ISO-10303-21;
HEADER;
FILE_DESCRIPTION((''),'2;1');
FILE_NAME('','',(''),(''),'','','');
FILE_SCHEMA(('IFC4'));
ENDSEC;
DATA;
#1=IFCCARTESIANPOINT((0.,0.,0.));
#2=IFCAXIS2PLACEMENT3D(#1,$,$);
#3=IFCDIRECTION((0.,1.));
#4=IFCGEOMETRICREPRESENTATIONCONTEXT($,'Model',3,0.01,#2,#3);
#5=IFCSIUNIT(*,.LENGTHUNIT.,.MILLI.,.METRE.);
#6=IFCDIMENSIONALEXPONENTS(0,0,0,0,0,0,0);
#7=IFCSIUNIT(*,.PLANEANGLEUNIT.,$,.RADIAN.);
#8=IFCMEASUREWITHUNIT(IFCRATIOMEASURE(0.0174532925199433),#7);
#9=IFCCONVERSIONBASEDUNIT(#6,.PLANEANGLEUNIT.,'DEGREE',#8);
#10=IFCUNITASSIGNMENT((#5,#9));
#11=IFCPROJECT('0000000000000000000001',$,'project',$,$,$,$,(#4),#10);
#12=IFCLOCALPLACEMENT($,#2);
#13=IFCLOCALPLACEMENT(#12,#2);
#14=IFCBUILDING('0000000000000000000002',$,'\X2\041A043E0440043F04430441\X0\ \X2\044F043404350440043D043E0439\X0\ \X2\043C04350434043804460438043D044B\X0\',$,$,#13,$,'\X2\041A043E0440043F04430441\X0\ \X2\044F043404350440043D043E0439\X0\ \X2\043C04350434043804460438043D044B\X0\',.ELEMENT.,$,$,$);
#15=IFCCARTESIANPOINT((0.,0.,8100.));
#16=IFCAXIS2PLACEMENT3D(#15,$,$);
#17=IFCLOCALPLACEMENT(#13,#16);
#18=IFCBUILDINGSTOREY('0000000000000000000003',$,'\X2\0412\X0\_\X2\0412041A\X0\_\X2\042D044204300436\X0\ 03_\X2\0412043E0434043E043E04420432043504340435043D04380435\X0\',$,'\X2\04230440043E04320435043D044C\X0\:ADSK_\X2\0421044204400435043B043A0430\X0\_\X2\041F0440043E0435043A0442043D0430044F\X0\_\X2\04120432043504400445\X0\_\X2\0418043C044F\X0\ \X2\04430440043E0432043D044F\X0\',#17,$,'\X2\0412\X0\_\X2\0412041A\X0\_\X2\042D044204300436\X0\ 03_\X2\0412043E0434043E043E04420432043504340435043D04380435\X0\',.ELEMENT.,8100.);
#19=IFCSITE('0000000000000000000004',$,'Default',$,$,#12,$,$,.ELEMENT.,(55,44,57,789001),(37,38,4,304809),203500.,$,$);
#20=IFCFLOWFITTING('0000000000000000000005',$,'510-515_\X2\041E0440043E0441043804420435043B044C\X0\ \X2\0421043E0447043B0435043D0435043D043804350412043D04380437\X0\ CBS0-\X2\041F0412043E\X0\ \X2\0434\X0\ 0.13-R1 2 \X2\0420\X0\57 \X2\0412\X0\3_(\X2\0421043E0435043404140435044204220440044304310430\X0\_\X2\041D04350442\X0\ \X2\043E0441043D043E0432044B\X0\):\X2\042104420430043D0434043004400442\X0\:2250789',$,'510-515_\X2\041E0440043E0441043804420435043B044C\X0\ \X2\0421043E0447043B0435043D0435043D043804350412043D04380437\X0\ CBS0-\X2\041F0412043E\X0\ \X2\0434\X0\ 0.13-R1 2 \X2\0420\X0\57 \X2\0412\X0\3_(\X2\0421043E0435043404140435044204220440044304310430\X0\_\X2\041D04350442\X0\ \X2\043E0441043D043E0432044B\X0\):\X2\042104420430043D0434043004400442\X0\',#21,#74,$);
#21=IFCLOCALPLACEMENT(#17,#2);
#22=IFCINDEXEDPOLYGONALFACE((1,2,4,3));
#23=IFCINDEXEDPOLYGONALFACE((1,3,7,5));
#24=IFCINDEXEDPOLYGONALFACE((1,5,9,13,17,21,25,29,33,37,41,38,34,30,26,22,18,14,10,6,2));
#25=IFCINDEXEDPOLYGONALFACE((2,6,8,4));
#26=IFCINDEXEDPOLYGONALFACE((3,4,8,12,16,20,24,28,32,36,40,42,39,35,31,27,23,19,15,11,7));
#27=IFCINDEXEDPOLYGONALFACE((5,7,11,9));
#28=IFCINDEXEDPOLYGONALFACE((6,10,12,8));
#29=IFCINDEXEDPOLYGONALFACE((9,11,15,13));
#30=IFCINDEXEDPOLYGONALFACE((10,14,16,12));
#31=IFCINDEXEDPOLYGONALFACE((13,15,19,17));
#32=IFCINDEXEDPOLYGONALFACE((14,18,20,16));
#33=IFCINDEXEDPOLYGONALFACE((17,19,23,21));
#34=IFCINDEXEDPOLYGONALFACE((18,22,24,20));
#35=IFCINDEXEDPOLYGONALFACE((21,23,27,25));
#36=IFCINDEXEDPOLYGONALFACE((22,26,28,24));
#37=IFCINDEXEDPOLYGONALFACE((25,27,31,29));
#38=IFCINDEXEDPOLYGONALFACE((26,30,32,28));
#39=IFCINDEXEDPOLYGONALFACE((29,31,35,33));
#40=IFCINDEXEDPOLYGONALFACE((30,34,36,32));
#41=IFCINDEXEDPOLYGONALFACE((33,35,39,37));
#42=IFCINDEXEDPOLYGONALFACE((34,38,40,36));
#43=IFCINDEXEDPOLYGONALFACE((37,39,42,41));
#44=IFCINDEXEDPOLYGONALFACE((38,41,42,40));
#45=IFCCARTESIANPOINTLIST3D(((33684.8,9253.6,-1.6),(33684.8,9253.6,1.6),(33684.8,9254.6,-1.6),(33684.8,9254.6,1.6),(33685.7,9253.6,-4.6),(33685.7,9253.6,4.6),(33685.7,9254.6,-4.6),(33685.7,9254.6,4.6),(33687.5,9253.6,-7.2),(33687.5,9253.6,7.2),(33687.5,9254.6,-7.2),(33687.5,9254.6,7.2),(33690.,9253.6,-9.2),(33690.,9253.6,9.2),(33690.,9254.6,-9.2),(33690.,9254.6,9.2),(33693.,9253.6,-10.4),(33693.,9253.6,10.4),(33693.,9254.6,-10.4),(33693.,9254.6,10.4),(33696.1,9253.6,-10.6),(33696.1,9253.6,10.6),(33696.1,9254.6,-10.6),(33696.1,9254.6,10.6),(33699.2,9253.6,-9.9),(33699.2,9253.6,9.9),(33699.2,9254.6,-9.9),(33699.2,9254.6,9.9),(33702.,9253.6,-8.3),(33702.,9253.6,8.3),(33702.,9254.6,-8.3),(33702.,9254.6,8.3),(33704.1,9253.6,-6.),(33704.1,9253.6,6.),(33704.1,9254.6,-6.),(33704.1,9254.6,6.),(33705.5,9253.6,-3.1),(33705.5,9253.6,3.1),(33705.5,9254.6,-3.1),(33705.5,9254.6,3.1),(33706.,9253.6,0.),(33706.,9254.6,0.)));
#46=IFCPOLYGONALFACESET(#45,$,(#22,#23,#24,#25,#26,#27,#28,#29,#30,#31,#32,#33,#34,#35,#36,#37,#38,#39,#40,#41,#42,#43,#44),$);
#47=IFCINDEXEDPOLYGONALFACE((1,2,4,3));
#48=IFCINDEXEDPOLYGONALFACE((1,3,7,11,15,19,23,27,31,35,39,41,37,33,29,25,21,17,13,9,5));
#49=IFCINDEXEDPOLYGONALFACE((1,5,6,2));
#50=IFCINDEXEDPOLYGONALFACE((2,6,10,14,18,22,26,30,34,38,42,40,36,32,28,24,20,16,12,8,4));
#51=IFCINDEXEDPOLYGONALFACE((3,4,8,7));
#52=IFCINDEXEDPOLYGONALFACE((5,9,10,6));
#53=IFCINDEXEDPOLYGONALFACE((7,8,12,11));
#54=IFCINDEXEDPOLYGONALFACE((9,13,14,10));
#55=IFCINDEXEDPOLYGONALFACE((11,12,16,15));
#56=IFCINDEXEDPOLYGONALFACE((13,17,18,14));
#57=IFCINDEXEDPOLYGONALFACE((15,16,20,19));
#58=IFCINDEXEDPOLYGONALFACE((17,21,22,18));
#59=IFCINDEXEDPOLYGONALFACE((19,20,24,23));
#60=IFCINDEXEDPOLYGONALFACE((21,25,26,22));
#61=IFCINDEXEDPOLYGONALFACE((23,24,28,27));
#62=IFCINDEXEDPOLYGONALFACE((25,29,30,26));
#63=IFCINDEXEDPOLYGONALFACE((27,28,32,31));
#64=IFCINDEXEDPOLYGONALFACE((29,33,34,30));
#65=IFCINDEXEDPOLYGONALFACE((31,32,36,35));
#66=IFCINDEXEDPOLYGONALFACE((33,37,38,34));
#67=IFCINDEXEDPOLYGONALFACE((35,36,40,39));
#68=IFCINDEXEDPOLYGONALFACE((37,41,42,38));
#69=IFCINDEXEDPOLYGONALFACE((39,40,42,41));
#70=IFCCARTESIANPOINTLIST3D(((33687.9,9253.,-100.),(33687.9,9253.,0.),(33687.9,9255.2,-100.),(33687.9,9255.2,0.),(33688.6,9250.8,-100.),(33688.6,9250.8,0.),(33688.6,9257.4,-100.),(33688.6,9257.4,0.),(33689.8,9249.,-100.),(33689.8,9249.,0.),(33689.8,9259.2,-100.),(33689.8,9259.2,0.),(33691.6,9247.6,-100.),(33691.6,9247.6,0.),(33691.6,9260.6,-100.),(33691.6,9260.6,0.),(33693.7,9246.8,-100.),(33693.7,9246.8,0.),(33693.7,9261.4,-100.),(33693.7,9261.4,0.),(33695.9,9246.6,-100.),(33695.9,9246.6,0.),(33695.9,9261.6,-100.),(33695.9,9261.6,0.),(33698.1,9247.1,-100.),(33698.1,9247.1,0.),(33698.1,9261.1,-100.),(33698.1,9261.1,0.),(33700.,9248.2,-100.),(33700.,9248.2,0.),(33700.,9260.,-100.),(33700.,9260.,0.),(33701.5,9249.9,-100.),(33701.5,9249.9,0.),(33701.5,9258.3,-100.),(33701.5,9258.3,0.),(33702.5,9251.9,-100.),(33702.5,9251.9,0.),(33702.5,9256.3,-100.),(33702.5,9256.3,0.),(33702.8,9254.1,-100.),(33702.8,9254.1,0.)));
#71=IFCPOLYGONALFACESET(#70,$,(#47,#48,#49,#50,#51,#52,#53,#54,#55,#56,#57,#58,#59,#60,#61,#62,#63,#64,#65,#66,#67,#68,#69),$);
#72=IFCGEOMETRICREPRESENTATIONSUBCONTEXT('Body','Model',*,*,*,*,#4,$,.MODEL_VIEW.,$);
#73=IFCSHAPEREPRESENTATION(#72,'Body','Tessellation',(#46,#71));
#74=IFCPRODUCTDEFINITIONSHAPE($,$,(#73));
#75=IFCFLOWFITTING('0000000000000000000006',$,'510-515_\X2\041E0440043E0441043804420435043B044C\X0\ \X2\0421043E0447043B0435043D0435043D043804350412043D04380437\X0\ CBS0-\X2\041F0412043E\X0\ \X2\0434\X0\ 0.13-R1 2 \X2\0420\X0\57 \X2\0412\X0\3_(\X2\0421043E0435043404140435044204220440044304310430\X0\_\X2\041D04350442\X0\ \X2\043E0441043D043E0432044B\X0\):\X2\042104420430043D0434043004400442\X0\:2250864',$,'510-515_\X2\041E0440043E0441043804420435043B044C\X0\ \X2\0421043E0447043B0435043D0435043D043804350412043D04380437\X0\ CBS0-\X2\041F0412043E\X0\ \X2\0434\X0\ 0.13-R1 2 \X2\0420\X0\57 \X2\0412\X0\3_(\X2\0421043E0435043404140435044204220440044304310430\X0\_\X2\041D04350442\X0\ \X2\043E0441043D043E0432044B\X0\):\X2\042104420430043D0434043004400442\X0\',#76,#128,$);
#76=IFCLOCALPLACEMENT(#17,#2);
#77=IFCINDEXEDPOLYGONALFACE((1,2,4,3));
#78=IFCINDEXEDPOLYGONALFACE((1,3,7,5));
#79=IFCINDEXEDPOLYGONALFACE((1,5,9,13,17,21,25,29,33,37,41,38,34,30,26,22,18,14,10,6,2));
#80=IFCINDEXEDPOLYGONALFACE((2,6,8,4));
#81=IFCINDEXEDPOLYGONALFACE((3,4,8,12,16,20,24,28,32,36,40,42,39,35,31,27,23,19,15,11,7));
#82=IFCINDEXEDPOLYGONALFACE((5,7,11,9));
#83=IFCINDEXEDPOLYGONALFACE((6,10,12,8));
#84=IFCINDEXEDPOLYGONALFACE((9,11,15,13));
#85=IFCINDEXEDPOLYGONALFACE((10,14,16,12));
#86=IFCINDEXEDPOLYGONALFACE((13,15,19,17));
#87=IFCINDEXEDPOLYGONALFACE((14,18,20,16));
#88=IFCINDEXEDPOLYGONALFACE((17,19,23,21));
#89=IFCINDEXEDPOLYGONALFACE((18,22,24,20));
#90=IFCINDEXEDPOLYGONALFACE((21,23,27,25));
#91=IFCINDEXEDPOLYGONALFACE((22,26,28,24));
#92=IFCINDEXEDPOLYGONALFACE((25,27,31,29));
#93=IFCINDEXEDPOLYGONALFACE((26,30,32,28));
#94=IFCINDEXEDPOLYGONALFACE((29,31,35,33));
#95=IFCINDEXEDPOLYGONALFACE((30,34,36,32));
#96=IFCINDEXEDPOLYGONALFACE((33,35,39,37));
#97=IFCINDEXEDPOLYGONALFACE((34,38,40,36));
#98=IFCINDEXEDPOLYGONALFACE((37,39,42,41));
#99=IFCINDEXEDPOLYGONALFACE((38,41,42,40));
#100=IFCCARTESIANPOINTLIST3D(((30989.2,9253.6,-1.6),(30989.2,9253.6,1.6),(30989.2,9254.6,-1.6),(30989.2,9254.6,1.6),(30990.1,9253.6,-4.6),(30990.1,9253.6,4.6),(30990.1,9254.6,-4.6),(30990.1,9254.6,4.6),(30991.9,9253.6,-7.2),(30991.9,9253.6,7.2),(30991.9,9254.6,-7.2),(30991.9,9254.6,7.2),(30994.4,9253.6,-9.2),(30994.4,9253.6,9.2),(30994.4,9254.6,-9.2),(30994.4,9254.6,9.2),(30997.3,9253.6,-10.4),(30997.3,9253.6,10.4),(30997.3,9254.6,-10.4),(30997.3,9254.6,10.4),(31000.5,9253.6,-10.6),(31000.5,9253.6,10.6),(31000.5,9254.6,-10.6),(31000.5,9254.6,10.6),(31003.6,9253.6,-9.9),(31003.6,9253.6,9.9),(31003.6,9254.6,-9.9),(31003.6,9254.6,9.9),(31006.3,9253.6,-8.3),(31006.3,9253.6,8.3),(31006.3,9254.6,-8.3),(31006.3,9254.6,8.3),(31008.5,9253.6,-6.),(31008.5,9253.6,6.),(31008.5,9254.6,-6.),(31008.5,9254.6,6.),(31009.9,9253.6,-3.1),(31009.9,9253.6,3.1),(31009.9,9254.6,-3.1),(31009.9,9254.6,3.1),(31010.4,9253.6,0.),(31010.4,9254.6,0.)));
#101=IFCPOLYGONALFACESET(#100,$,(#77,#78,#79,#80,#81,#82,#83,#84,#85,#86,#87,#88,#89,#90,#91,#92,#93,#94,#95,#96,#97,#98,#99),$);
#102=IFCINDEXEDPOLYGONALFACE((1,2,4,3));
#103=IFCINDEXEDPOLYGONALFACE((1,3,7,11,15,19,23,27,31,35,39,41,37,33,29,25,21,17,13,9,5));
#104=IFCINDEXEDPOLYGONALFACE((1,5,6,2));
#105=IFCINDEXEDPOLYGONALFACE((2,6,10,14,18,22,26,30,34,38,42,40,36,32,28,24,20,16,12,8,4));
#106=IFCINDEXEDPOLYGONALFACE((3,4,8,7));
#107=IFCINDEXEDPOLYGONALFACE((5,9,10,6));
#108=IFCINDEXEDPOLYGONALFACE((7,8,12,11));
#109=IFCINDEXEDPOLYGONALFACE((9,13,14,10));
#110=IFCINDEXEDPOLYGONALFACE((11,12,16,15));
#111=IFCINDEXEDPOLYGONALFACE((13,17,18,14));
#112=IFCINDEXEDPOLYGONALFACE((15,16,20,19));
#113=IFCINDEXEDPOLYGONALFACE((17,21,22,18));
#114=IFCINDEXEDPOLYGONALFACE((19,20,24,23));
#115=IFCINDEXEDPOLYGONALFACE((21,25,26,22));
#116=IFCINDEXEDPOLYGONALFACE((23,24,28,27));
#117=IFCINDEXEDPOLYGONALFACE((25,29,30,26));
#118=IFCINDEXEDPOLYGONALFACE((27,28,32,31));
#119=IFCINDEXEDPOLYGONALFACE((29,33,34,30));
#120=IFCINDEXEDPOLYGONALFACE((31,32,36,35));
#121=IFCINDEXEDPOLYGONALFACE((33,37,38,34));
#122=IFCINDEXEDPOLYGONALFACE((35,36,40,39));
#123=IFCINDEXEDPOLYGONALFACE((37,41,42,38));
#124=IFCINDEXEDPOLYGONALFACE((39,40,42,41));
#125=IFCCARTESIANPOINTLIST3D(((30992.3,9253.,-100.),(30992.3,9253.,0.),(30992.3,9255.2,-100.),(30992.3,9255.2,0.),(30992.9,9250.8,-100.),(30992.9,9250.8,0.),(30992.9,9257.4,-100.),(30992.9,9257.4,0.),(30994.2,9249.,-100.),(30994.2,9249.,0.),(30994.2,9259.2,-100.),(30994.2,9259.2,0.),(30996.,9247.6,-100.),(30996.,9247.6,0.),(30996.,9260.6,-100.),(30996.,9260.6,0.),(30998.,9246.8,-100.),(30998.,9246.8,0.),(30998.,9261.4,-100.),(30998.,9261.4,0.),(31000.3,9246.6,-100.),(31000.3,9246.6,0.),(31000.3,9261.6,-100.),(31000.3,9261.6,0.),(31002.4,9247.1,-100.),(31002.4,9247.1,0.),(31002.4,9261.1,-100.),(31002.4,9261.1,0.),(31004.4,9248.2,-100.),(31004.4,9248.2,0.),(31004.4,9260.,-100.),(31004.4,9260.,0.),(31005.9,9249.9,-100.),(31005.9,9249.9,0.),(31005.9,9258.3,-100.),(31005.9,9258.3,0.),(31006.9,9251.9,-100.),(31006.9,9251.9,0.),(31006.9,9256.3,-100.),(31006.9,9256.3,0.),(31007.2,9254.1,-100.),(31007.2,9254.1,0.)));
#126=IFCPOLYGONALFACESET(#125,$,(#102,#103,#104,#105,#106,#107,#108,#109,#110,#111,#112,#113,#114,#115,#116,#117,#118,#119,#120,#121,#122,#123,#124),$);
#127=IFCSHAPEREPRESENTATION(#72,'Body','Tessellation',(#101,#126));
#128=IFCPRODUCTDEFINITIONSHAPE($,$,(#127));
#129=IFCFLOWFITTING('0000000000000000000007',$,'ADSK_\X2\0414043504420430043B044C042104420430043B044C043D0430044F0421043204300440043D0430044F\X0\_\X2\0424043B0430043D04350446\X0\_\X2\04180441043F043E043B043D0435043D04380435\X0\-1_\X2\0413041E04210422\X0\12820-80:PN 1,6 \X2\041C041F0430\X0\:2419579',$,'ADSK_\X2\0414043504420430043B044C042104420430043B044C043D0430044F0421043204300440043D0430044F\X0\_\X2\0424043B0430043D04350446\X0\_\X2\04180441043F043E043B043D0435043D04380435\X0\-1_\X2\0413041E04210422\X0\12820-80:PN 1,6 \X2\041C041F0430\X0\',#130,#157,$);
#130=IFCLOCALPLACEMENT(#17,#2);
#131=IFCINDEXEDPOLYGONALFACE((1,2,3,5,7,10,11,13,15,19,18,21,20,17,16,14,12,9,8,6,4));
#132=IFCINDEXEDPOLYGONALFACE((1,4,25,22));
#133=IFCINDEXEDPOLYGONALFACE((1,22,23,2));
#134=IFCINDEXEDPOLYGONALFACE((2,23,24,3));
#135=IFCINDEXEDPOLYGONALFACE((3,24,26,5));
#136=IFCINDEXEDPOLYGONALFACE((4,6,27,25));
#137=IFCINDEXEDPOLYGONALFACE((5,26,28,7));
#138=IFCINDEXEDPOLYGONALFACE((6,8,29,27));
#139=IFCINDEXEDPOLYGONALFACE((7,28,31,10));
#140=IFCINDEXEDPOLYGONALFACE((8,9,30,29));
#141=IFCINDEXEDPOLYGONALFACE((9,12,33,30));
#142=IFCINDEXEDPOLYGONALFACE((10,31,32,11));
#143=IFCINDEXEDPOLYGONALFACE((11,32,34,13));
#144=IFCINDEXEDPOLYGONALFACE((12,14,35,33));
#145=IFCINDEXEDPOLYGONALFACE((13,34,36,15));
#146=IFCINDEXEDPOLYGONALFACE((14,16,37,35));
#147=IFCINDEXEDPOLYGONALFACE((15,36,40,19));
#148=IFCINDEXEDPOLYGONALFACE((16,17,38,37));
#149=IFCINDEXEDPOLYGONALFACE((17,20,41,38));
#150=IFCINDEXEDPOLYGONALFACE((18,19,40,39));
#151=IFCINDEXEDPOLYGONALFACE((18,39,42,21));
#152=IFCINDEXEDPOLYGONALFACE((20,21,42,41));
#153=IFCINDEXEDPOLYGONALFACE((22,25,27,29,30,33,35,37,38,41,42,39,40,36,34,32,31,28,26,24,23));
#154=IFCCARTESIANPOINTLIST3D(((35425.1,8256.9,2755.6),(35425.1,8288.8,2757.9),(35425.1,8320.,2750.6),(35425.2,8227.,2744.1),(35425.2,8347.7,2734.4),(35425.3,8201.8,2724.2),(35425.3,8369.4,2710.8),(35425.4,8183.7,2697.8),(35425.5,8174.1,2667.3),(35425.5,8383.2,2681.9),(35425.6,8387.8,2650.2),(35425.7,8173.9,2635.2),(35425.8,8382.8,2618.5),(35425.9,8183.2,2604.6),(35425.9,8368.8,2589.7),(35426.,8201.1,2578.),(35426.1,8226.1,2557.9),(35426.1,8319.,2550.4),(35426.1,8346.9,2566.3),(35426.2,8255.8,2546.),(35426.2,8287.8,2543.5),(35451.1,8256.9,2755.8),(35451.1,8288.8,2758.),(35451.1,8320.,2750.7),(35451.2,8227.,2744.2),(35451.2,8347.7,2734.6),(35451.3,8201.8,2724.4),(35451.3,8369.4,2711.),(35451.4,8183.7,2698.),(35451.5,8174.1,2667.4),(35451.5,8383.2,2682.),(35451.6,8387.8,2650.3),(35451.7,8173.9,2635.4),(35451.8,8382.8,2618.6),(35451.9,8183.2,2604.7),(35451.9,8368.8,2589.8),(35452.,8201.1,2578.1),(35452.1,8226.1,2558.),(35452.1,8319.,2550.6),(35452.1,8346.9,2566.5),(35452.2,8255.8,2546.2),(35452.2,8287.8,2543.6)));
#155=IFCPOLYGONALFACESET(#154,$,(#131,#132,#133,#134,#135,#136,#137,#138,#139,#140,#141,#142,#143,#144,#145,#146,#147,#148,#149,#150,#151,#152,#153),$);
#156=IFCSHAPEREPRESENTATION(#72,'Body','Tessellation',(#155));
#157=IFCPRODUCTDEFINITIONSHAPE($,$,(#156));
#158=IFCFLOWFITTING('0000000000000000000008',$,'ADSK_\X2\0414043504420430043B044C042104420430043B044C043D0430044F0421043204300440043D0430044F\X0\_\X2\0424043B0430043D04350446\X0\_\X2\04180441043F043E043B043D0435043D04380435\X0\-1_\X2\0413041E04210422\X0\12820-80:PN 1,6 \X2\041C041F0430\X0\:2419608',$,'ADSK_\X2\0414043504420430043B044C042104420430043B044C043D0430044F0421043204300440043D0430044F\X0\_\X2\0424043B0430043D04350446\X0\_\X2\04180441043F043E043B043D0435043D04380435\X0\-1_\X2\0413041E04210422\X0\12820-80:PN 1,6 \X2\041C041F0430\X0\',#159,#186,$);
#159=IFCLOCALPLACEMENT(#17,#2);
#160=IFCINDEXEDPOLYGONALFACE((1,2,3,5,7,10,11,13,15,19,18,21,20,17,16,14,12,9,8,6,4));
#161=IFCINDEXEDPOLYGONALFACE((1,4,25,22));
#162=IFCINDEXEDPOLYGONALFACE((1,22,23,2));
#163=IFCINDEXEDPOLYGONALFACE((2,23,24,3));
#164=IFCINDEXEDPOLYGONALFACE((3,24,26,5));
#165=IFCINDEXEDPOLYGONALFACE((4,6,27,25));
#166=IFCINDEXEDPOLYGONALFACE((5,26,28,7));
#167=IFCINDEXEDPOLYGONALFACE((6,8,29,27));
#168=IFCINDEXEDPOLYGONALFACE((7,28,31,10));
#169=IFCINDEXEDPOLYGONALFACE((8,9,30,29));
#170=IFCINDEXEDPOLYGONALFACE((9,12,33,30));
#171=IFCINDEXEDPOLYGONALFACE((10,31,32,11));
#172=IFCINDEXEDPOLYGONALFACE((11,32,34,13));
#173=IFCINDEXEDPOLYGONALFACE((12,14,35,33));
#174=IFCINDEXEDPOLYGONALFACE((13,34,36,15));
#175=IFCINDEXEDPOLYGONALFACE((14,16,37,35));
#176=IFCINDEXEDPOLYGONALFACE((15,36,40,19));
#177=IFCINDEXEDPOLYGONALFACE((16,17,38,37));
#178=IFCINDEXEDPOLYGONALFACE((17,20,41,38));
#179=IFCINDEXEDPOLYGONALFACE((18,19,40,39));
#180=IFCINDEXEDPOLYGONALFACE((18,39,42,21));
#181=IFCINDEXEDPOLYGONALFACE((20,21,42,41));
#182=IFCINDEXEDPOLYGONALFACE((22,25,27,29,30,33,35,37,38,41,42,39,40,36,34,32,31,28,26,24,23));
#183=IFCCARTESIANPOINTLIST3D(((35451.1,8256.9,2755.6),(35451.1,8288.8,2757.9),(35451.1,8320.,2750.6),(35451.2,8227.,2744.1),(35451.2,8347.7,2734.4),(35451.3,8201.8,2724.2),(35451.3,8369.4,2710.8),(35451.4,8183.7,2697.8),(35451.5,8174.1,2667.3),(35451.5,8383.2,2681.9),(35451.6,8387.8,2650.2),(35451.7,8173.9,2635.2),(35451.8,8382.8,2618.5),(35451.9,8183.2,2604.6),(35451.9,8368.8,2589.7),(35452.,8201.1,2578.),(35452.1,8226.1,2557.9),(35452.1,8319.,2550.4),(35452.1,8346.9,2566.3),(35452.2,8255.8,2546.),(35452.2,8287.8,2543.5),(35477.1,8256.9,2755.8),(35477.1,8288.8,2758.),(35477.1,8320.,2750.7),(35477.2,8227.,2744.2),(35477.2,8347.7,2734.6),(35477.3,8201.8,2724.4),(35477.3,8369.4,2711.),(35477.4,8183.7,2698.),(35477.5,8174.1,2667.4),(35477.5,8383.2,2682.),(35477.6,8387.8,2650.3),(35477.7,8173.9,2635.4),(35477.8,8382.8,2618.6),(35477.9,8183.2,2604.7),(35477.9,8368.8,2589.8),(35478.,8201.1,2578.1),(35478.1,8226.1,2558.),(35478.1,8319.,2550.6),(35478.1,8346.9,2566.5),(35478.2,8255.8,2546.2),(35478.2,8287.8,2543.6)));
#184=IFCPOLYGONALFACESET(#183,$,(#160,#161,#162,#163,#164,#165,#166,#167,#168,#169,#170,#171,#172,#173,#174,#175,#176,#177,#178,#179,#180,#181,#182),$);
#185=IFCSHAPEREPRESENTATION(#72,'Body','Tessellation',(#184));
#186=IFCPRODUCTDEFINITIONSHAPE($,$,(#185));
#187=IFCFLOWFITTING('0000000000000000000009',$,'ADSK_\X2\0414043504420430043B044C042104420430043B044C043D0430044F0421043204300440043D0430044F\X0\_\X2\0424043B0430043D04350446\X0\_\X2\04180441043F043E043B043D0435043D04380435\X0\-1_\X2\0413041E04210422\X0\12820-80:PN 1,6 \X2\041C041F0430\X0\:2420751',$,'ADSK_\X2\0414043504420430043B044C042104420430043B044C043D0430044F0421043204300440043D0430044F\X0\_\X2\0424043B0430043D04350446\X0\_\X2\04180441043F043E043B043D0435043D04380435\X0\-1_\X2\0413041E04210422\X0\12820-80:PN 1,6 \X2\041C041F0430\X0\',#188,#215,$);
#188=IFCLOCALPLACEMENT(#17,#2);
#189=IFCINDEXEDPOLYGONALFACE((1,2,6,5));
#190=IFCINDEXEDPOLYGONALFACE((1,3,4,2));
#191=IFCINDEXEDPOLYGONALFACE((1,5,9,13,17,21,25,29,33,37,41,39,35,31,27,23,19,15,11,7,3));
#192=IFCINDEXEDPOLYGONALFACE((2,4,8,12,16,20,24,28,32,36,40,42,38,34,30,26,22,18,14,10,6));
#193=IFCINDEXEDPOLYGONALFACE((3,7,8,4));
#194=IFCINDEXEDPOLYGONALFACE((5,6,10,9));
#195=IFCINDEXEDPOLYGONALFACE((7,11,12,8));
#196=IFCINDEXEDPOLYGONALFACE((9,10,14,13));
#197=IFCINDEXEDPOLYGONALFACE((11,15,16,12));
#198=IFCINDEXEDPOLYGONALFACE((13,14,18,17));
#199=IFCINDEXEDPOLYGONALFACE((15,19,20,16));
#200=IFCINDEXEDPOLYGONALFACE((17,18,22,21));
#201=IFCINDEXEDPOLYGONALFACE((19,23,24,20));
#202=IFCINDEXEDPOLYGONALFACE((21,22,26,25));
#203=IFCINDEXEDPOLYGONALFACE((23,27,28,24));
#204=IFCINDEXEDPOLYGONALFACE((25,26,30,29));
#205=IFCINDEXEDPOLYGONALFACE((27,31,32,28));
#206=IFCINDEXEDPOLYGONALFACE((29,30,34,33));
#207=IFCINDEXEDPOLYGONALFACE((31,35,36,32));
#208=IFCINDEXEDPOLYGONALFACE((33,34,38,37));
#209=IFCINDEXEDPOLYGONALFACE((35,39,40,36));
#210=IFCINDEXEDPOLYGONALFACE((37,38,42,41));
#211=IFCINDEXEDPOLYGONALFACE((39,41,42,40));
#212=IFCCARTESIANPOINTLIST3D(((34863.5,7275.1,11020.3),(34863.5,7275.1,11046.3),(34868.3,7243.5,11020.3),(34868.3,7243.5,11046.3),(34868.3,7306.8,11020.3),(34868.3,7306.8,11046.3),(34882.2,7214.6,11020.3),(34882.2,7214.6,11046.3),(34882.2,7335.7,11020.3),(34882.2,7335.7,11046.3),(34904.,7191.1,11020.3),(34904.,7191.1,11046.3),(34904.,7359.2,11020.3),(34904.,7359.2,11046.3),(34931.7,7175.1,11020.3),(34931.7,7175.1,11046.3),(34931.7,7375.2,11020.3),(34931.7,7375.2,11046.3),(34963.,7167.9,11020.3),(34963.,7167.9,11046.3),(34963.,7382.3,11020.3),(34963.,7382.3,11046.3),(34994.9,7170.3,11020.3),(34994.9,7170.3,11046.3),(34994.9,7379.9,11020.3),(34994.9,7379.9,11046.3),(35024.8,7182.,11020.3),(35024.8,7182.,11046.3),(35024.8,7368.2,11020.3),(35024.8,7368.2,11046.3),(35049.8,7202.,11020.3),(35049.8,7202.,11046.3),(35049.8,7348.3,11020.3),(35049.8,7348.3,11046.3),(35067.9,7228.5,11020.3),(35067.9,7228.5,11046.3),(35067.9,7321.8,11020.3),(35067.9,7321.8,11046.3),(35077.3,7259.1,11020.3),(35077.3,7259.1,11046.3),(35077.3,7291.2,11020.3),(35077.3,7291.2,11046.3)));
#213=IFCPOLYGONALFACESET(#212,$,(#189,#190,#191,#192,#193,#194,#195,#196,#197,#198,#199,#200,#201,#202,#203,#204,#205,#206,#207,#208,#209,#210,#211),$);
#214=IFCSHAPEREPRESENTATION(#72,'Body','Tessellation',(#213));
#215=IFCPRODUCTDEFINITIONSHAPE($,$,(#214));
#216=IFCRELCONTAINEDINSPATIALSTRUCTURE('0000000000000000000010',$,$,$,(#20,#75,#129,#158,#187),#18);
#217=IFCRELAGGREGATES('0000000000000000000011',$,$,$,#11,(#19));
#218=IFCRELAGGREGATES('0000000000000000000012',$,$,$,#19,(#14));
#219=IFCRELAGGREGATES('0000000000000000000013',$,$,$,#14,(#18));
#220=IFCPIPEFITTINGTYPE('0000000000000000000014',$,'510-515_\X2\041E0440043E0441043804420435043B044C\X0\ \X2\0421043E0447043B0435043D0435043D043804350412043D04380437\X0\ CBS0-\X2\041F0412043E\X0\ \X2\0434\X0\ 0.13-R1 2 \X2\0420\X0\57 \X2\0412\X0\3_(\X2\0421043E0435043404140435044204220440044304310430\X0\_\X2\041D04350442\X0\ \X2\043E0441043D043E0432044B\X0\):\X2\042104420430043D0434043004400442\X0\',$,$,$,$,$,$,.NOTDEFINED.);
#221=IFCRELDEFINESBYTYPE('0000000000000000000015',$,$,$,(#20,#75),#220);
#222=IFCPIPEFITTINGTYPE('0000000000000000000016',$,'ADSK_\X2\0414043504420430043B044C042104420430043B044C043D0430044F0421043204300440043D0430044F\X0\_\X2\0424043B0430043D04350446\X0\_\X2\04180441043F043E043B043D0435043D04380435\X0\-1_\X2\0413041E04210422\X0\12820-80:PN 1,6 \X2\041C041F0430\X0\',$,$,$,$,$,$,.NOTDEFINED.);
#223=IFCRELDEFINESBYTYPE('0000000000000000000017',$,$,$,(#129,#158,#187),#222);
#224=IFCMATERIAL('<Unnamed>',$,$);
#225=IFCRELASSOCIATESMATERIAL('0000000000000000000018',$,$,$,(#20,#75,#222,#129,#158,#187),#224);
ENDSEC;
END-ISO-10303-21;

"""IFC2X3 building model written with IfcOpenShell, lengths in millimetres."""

from ifc_helpers import new_model, entity, si_unit, converted_unit, direction, frame, origin, origin_2d_with_axis, place, context, subcontext, project, spatial, circle, extrude, source, transform, mapped, material, type_object, type_shapes, element, save


model = new_model("IFC2X3")

# Units and contexts
model_context = context("Model", 3, precision=0.01, world=origin(), true_north=direction((0.0, 1.0)))
body_context = subcontext(model_context, "Body", "Model", "MODEL_VIEW")
ifc_project = project(units=[si_unit("LENGTHUNIT", "METRE", prefix="MILLI"), converted_unit("PLANEANGLEUNIT", "DEGREE", entity("IfcRatioMeasure", 0.0174532925199433), si_unit("PLANEANGLEUNIT", "RADIAN"), dimensions=[0, 0, 0, 0, 0, 0, 0])], contexts=[model_context])

# Site, building, storey
site_placement = place(None, origin())
site = spatial("IfcSite", under=ifc_project, at=site_placement, Name="Default", CompositionType="ELEMENT", RefLatitude=(55, 44, 57, 789001), RefLongitude=(37, 38, 4, 304809), RefElevation=203500.0)
building_placement = place(site_placement, origin())
building = spatial("IfcBuilding", under=site, at=building_placement, Name="Корпус ядерной медицины", LongName="Корпус ядерной медицины", CompositionType="ELEMENT")
storey_placement = place(building_placement, frame((0.0, 0.0, 8100.0)))
storey = spatial("IfcBuildingStorey", under=building, at=storey_placement, Name="В_ВК_Этаж 03_Водоотведение", ObjectType="Уровень:ADSK_Стрелка_Проектная_Вверх_Имя уровня", LongName="В_ВК_Этаж 03_Водоотведение", CompositionType="ELEMENT", Elevation=8100.0)

# Flow fittings
ifc_material = material(Name="<Unnamed>")
pipe_fitting_type_1 = type_object("IfcPipeFittingType", Name="510-515_Ороситель СочленениеВниз CBS0-ПВо д 0.13-R1 2 Р57 В3_(СоедДетТруба_Нет основы):Стандарт", PredefinedType="NOTDEFINED")
shared_shape_1 = source(origin(), body_context, "Body", "SweptSolid", [
    extrude(circle(Radius=10.7, at=origin_2d_with_axis()), frame((-0.5, 0.0, 0.0), z_axis=(1.0, 0.0, 0.0), x_axis=(0.0, 1.0, 0.0)), (0.0, 0.0, 1.0), 1.0),
    extrude(circle(Radius=7.5, at=origin_2d_with_axis()), frame((0.0, 0.0, -100.0), z_axis=(0.0, 0.0, 1.0), x_axis=(0.0, 1.0, 0.0)), (0.0, 0.0, 1.0), 100.0),
])
type_shapes(pipe_fitting_type_1, [shared_shape_1])
for number, where, z_axis, x_axis, name in (
    (1, (33695.3, 9254.1, 0.0), (0.0, 0.0, 1.0), (0.0, -1.0, 0.0), "510-515_Ороситель СочленениеВниз CBS0-ПВо д 0.13-R1 2 Р57 В3_(СоедДетТруба_Нет основы):Стандарт:2250789"),
    (2, (30999.7, 9254.1, 0.0), (0.0, 0.0, 1.0), (0.0, -1.0, 0.0), "510-515_Ороситель СочленениеВниз CBS0-ПВо д 0.13-R1 2 Р57 В3_(СоедДетТруба_Нет основы):Стандарт:2250864"),
):
    element("IfcFlowFitting", number, at=place(storey_placement, frame(where, z_axis=z_axis, x_axis=x_axis)), inside=storey, type_object=pipe_fitting_type_1, material=ifc_material, Name=name, ObjectType="510-515_Ороситель СочленениеВниз CBS0-ПВо д 0.13-R1 2 Р57 В3_(СоедДетТруба_Нет основы):Стандарт", context=body_context, shape_type="MappedRepresentation", body=[
        mapped(shared_shape_1, transform((0.0, 0.0, 0.0), scale=1.0)),
    ])
pipe_fitting_type_2 = type_object("IfcPipeFittingType", Name="ADSK_ДетальСтальнаяСварная_Фланец_Исполнение-1_ГОСТ12820-80:PN 1,6 МПа", PredefinedType="NOTDEFINED", material=ifc_material)
shared_shape_2 = source(origin(), body_context, "Body", "SweptSolid", [
    extrude(circle(Radius=107.5, at=origin_2d_with_axis()), frame((0.0, 0.0, 0.0), z_axis=(1.0, 0.0, 0.0), x_axis=(0.0, 1.0, 0.0)), (0.0, 0.0, 1.0), 26.0),
])
type_shapes(pipe_fitting_type_2, [shared_shape_2])
for number, where, z_axis, x_axis, name in (
    (3, (35425.6, 8280.3, 2650.7), (-0.005041, 0.005, 0.999975), (0.999987, 0.0, 0.005041), "ADSK_ДетальСтальнаяСварная_Фланец_Исполнение-1_ГОСТ12820-80:PN 1,6 МПа:2419579"),
    (4, (35451.6, 8280.3, 2650.7), (-0.005041, 0.005, 0.999975), (0.999987, 0.0, 0.005041), "ADSK_ДетальСтальнаяСварная_Фланец_Исполнение-1_ГОСТ12820-80:PN 1,6 МПа:2419608"),
    (5, (34971.0, 7275.1, 11020.3), (0.0, -1.0, 0.000001), (0.0, 0.000001, 1.0), "ADSK_ДетальСтальнаяСварная_Фланец_Исполнение-1_ГОСТ12820-80:PN 1,6 МПа:2420751"),
):
    element("IfcFlowFitting", number, at=place(storey_placement, frame(where, z_axis=z_axis, x_axis=x_axis)), inside=storey, type_object=pipe_fitting_type_2, material=ifc_material, Name=name, ObjectType="ADSK_ДетальСтальнаяСварная_Фланец_Исполнение-1_ГОСТ12820-80:PN 1,6 МПа", context=body_context, shape_type="MappedRepresentation", body=[
        mapped(shared_shape_2, transform((0.0, 0.0, 0.0), scale=1.0)),
    ])

save(model, "model.ifc")
